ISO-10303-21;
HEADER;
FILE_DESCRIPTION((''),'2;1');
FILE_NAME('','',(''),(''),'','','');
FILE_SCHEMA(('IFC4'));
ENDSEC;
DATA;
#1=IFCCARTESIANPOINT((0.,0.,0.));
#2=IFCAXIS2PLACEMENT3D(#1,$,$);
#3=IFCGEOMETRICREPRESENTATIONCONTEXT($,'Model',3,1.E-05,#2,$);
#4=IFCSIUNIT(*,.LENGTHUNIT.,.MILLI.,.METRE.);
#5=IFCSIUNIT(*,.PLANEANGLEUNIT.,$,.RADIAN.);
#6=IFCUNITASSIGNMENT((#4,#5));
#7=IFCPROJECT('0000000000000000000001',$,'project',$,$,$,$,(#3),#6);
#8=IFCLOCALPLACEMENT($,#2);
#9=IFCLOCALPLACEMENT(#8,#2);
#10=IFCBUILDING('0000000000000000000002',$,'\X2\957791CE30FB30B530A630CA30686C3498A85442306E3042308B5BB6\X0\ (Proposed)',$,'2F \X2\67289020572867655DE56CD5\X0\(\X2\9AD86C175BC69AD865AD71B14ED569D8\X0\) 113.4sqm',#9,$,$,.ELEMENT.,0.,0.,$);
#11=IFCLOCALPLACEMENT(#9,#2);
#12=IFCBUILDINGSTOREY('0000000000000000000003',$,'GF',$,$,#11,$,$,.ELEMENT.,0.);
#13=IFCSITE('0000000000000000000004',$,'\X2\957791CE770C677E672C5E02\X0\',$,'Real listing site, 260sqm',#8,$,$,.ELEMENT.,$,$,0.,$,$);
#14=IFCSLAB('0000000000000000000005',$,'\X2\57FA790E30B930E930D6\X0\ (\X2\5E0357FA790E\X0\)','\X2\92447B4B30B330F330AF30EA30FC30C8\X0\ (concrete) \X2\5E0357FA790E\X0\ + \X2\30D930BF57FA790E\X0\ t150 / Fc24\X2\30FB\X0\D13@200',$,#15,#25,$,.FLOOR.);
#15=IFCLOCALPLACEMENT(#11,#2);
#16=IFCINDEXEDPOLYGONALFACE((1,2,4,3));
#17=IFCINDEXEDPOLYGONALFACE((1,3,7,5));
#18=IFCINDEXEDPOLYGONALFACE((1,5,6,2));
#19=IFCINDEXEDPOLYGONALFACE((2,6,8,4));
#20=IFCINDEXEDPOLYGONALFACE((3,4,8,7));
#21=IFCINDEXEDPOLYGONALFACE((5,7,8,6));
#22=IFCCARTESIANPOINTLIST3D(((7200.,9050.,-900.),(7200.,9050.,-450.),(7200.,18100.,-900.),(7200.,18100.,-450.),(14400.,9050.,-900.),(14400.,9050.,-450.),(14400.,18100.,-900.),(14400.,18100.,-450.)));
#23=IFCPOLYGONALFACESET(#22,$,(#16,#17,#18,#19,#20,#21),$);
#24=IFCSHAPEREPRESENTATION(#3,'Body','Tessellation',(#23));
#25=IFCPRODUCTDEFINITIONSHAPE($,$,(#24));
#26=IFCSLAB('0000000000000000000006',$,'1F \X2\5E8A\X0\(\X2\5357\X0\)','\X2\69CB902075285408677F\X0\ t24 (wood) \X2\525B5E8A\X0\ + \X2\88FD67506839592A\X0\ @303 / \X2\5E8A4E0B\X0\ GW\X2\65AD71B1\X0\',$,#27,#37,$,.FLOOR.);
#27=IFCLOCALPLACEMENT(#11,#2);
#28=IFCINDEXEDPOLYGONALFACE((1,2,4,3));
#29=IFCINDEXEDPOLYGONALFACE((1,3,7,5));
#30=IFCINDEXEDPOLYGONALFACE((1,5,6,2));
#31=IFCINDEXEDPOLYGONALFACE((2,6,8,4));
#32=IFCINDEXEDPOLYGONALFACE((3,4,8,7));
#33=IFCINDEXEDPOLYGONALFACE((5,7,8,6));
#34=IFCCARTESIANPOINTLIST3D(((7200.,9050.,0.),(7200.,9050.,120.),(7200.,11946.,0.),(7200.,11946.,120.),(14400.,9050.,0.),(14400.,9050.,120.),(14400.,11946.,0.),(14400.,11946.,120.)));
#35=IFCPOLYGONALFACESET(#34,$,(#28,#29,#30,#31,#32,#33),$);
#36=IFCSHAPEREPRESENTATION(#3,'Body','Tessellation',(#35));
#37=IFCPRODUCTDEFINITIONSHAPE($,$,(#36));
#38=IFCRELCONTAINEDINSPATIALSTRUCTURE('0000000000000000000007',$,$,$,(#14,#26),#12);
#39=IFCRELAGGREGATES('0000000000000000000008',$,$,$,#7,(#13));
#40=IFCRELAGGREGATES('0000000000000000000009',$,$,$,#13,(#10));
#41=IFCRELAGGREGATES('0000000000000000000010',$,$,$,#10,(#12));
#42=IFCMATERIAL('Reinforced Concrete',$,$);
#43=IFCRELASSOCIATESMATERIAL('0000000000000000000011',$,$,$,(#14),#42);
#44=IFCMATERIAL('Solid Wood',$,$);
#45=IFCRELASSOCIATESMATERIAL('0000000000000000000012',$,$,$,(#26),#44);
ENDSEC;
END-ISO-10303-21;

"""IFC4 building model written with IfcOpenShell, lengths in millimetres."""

from ifc_helpers import new_model, si_unit, frame, frame_2d, origin, place, context, project, spatial, rectangle, extrude, material, element, save


model = new_model("IFC4")

# Units and contexts
model_context = context("Model", 3, precision=1e-05, world=origin())
ifc_project = project(units=[si_unit("LENGTHUNIT", "METRE", prefix="MILLI"), si_unit("PLANEANGLEUNIT", "RADIAN")], contexts=[model_context])

# Site, building, storey
site_placement = place(None, origin())
site = spatial("IfcSite", under=ifc_project, at=site_placement, Name="長野県松本市", ObjectType="Real listing site, 260sqm", CompositionType="ELEMENT", RefElevation=0.0)
building_placement = place(site_placement, origin())
building = spatial("IfcBuilding", under=site, at=building_placement, Name="長野・サウナと水風呂のある家 (Proposed)", ObjectType="2F 木造在来工法(高気密高断熱仕様) 113.4sqm", CompositionType="ELEMENT", ElevationOfRefHeight=0.0, ElevationOfTerrain=0.0)
storey_placement = place(building_placement, origin())
storey = spatial("IfcBuildingStorey", under=building, at=storey_placement, Name="GF", CompositionType="ELEMENT", Elevation=0.0)

# Shared definitions
ifc_material_1 = material(Name="Solid Wood")

# Slabs
ifc_material_2 = material(Name="Reinforced Concrete")
slab_1_placement = place(storey_placement, frame((3600.0, 4525.0, -450.0)))
element("IfcSlab", 1, at=slab_1_placement, inside=storey, material=ifc_material_2, Name="基礎スラブ (布基礎)", Description="鉄筋コンクリート (concrete) 布基礎 + ベタ基礎 t150 / Fc24・D13@200", PredefinedType="FLOOR", context=model_context, shape_type="SweptSolid", body=[
    extrude(rectangle(XDim=7200.0, YDim=9050.0, at=frame_2d((3600.0, 4525.0))), frame((3600.0, 4525.0, -450.0)), (0.0, 0.0, 1.0), 450.0),
])
slab_2_placement = place(storey_placement, frame((3600.0, 4525.0, 0.0)))
element("IfcSlab", 2, at=slab_2_placement, inside=storey, material=ifc_material_1, Name="1F 床(南)", Description="構造用合板 t24 (wood) 剛床 + 製材根太 @303 / 床下 GW断熱", PredefinedType="FLOOR", context=model_context, shape_type="SweptSolid", body=[
    extrude(rectangle(XDim=7200.0, YDim=2896.0, at=frame_2d((3600.0, 1448.0))), frame((3600.0, 4525.0, 0.0)), (0.0, 0.0, 1.0), 120.0),
])

save(model, "model.ifc")
